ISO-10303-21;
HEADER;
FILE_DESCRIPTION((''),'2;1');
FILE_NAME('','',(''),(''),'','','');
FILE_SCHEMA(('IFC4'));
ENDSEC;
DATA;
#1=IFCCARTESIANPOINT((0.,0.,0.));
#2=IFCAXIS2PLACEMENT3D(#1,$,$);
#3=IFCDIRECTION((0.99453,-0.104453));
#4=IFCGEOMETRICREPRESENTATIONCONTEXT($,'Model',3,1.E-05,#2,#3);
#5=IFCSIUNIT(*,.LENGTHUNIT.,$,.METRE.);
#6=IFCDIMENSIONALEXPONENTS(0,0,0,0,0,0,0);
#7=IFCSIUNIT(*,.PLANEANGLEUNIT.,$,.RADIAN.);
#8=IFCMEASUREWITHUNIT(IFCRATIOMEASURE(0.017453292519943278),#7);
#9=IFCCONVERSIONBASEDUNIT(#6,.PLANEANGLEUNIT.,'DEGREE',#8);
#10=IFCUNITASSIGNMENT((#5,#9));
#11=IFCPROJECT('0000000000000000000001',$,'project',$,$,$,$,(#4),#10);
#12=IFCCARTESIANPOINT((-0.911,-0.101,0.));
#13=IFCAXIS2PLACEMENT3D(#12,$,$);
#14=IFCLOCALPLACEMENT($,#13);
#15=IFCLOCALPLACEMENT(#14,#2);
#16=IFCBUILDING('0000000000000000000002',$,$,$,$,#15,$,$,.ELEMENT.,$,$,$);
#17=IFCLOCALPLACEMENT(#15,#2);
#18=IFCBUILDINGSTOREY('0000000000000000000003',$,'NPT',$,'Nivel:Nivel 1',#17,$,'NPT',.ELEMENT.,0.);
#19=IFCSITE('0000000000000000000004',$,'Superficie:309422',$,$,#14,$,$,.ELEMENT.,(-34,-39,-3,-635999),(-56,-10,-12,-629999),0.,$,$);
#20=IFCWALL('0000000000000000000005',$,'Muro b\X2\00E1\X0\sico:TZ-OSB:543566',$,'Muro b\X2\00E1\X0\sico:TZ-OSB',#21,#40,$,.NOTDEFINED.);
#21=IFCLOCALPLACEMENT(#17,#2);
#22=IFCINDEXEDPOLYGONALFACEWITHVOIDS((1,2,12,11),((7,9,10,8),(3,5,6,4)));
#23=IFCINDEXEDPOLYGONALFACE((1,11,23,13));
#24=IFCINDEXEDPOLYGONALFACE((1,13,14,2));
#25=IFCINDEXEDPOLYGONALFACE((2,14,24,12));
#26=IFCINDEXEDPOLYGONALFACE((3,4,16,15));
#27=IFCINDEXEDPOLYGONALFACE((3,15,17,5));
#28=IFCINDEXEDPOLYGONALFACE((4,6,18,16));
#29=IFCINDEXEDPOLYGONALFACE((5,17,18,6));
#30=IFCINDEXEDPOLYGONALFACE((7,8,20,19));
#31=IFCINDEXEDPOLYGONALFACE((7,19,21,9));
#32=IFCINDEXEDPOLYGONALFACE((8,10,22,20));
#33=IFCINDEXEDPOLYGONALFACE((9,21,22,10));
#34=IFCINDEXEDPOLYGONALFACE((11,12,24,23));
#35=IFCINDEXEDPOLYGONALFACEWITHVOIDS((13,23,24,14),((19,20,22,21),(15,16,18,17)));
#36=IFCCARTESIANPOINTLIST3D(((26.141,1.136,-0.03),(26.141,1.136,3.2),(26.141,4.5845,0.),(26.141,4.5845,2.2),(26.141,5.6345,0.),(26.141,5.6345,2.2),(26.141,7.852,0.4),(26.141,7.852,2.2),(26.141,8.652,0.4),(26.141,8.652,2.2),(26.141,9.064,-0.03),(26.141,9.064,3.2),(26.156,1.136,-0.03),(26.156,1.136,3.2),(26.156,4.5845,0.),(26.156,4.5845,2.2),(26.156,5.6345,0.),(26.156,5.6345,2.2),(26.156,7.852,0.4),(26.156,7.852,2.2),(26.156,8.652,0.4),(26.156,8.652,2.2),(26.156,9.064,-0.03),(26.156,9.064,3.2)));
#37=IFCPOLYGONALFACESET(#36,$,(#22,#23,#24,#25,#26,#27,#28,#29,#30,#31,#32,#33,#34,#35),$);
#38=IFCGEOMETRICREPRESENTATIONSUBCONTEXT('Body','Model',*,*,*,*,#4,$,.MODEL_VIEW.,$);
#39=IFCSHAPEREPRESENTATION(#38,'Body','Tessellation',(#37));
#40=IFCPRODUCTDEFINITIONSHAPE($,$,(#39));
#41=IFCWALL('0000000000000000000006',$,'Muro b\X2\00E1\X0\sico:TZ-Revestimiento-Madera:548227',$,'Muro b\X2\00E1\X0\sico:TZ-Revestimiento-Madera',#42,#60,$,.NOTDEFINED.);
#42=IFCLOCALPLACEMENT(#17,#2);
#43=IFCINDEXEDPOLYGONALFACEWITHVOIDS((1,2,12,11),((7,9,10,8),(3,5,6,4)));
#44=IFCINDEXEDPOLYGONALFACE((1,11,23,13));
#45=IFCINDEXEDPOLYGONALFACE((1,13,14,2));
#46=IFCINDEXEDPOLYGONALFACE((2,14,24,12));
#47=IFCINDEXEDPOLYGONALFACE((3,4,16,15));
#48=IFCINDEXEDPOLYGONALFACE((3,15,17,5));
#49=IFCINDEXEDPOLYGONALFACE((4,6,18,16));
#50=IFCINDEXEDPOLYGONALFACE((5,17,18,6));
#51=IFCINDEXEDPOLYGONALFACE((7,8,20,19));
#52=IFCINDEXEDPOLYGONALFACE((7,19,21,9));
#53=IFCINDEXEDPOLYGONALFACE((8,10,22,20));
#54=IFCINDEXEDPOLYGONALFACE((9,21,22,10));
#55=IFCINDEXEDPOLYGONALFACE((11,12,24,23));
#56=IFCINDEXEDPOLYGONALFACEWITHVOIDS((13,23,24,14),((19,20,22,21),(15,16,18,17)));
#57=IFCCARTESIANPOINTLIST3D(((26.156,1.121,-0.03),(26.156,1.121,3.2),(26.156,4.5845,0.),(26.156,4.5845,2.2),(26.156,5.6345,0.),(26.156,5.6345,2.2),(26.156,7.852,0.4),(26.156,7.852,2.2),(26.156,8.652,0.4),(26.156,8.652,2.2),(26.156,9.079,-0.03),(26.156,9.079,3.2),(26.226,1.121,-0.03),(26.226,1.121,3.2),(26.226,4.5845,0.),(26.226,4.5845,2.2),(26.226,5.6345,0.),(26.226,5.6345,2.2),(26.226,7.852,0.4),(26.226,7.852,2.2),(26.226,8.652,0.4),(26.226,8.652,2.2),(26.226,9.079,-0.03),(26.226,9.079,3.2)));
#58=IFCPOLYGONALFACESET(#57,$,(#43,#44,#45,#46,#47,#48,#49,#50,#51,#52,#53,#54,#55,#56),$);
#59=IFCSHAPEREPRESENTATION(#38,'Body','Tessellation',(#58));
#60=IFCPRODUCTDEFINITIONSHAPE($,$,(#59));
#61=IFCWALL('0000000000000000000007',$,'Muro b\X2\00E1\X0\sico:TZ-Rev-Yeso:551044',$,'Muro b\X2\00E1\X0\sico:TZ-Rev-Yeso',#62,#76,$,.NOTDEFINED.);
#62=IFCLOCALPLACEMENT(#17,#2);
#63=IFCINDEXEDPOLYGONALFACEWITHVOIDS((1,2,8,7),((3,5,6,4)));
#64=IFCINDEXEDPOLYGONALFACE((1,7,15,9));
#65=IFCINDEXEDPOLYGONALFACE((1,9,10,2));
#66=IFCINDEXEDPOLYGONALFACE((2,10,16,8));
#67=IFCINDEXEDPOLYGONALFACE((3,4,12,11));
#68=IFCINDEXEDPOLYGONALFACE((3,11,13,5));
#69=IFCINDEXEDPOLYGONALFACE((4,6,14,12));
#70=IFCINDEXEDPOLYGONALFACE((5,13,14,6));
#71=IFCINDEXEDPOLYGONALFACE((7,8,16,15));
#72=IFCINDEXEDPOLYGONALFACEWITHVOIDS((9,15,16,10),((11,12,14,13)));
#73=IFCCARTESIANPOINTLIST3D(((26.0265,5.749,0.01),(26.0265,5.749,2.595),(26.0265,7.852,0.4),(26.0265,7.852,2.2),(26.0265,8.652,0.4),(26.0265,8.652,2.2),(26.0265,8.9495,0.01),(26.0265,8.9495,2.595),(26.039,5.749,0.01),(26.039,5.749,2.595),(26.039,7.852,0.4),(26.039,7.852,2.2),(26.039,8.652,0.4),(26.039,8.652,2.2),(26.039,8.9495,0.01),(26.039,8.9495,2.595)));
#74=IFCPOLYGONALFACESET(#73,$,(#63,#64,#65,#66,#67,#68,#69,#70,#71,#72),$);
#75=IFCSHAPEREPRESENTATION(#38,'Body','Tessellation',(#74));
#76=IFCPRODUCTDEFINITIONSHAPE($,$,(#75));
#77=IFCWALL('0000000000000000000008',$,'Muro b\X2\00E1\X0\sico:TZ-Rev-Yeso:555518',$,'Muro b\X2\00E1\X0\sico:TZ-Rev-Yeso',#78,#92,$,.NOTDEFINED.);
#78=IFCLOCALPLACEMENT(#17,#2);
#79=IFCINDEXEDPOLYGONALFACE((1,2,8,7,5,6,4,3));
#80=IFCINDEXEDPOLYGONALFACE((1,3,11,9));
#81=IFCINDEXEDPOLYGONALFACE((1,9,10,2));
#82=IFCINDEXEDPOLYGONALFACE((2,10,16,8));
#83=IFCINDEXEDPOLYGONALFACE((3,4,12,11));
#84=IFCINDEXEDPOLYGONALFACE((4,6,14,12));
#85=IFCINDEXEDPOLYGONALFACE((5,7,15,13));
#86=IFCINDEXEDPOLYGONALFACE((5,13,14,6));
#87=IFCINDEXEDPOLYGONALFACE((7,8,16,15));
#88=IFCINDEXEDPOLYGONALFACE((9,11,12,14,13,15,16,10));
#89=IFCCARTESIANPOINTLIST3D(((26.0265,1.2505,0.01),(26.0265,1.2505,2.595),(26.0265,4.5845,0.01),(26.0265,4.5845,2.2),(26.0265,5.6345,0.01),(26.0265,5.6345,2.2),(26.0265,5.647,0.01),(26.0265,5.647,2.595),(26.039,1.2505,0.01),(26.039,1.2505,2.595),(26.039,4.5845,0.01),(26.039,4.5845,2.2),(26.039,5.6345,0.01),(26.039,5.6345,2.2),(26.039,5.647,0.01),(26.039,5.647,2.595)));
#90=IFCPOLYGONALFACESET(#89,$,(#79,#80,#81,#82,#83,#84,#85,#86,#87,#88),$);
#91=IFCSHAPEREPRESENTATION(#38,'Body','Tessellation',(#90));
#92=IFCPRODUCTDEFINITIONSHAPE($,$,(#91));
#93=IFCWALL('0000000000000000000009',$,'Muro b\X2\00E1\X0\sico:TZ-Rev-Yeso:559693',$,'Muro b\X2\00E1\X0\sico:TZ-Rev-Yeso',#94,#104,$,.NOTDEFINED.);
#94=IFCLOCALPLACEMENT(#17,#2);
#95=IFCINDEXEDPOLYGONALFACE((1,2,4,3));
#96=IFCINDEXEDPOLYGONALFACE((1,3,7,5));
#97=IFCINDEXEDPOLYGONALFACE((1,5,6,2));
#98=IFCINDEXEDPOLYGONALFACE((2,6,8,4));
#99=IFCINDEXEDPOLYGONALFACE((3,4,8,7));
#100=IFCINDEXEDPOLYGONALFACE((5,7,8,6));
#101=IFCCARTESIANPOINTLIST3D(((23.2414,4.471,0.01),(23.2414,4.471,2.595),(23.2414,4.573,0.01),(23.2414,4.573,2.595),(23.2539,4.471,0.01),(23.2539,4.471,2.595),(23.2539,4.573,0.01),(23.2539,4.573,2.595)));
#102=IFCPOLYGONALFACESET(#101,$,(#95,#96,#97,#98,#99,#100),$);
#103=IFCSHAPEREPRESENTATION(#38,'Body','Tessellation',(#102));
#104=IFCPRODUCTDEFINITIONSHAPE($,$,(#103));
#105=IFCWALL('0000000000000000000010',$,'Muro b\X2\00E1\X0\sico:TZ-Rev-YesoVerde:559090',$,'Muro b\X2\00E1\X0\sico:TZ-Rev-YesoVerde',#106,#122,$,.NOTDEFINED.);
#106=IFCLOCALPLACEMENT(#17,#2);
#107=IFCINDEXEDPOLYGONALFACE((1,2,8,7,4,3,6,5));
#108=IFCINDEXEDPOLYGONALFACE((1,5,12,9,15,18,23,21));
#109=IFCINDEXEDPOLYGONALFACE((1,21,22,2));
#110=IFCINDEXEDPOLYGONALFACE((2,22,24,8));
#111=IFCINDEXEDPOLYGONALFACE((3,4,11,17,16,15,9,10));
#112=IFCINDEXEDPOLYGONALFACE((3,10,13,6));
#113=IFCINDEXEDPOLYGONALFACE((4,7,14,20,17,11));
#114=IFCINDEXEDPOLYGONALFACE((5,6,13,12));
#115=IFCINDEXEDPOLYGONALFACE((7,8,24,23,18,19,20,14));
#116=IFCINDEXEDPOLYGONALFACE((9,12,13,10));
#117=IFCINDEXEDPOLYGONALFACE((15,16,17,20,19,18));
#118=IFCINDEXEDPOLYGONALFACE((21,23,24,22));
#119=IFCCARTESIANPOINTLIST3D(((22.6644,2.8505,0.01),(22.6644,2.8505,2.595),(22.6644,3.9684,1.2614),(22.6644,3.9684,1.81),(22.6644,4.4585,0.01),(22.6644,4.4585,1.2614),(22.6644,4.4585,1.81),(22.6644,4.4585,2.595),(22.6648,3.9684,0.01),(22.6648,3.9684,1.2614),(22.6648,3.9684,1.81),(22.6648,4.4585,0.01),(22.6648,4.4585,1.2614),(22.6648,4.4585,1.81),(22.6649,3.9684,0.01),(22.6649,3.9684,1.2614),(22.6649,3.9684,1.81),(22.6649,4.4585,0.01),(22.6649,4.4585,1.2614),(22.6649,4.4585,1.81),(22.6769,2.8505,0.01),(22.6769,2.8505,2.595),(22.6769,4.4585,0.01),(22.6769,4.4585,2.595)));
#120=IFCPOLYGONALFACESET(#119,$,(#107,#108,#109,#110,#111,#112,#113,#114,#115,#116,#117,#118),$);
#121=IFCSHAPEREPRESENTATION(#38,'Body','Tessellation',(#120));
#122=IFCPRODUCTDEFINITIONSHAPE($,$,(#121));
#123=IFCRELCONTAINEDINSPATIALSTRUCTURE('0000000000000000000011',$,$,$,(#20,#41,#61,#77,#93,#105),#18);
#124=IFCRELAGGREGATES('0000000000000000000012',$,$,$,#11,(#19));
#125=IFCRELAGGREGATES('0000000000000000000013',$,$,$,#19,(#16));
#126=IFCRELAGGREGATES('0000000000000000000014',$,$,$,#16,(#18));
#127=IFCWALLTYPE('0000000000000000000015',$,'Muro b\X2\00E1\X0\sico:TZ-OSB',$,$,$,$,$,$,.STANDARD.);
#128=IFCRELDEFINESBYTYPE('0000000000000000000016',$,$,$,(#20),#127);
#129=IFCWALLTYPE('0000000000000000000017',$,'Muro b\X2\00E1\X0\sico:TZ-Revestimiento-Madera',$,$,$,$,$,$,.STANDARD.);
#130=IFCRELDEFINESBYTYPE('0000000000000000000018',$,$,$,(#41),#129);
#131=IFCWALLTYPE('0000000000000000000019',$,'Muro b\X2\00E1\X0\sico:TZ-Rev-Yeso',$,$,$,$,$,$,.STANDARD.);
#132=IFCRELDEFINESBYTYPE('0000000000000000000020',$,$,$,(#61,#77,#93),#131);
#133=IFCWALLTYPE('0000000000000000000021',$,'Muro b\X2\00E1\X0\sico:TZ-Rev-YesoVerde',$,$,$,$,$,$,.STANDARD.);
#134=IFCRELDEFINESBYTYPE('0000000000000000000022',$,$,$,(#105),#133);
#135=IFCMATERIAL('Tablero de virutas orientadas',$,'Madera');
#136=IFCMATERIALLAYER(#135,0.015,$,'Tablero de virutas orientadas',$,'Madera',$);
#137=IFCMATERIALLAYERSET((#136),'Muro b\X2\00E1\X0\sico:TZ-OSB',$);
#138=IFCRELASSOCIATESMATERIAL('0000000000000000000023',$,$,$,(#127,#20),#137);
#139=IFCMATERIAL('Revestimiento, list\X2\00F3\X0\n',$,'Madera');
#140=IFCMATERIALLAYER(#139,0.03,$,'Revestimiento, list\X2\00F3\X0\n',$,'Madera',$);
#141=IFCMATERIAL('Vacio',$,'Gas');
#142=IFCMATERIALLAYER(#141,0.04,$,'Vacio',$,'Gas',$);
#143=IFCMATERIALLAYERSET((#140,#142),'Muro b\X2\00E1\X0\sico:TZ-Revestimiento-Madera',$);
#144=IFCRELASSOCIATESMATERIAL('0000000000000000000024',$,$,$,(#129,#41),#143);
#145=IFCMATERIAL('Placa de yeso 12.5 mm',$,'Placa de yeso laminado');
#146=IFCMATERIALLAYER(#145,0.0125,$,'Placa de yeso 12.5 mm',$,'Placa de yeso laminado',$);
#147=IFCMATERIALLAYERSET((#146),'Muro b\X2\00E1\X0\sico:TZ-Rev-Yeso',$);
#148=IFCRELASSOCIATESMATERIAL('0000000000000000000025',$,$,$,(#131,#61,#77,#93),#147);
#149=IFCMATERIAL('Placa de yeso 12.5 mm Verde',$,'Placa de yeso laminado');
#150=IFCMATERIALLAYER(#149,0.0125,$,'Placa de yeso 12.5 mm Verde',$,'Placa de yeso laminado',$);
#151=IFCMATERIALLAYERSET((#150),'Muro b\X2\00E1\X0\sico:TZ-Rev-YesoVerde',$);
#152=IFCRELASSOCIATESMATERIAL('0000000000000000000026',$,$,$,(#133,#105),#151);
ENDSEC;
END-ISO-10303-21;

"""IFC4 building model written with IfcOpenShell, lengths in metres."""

from ifc_helpers import new_model, entity, si_unit, converted_unit, direction, frame, frame_2d, origin, place, context, subcontext, project, spatial, polyline, rectangle, extrude, clip, bounded_halfspace, material, layer, layer_set, layer_usage, type_object, element, save


model = new_model("IFC4")

# Units and contexts
model_context = context("Model", 3, precision=1e-05, world=origin(), true_north=direction((0.99453, -0.104453)))
body_context = subcontext(model_context, "Body", "Model", "MODEL_VIEW")
ifc_project = project(units=[si_unit("LENGTHUNIT", "METRE"), converted_unit("PLANEANGLEUNIT", "DEGREE", entity("IfcRatioMeasure", 0.017453292519943278), si_unit("PLANEANGLEUNIT", "RADIAN"), dimensions=[0, 0, 0, 0, 0, 0, 0])], contexts=[model_context])

# Site, building, storey
site_placement = place(None, frame((-0.911, -0.101, 0.0)))
site = spatial("IfcSite", under=ifc_project, at=site_placement, Name="Superficie:309422", CompositionType="ELEMENT", RefLatitude=(-34, -39, -3, -635999), RefLongitude=(-56, -10, -12, -629999), RefElevation=0.0)
building_placement = place(site_placement, origin())
building = spatial("IfcBuilding", under=site, at=building_placement, CompositionType="ELEMENT")
storey_placement = place(building_placement, origin())
storey = spatial("IfcBuildingStorey", under=building, at=storey_placement, Name="NPT", ObjectType="Nivel:Nivel 1", LongName="NPT", CompositionType="ELEMENT", Elevation=0.0)

# Walls, openings
ifc_material_1 = material(Name="Tablero de virutas orientadas", Category="Madera")
ifc_layer_1 = layer(ifc_material_1, 0.015, Name="Tablero de virutas orientadas", Category="Madera")
ifc_layer_set_1 = layer_set([ifc_layer_1], Name="Muro básico:TZ-OSB")
ifc_layer_usage_1 = layer_usage(ifc_layer_set_1, "AXIS2", "NEGATIVE", 0.0075)
wall_type_1 = type_object("IfcWallType", Name="Muro básico:TZ-OSB", PredefinedType="STANDARD", material=ifc_layer_set_1)
wall_1_placement = place(storey_placement, frame((26.1485, 9.064, -0.03), z_axis=(0.0, 0.0, 1.0), x_axis=(0.0, -1.0, 0.0)))
wall_1 = element("IfcWall", 1, at=wall_1_placement, inside=storey, type_object=wall_type_1, material=ifc_layer_usage_1, Name="Muro básico:TZ-OSB:543566", ObjectType="Muro básico:TZ-OSB", PredefinedType="NOTDEFINED", context=body_context, shape_type="SweptSolid", body=[
    extrude(rectangle(XDim=7.928, YDim=0.015, at=frame_2d((3.964, 0.0), x_axis=(-1.0, 0.0))), origin(), (0.0, 0.0, 1.0), 3.23),
])
opening_1_placement = place(wall_1_placement, frame((4.4795, -1.6335, 0.03)))
element("IfcOpeningElement", 2, at=opening_1_placement, cuts=wall_1, PredefinedType="OPENING", context=body_context, shape_type="SweptSolid", body=[
    extrude(rectangle(XDim=2.2, YDim=1.05, at=frame_2d((0.0, 0.0), x_axis=(1.0, 0.0))), frame((-0.525, 0.0, 1.1), z_axis=(0.0, 1.0, 0.0), x_axis=(0.0, 0.0, 1.0)), (0.0, 0.0, 1.0), 3.048),
])
opening_2_placement = place(wall_1_placement, frame((1.212, -1.6335, 0.43)))
element("IfcOpeningElement", 3, at=opening_2_placement, cuts=wall_1, PredefinedType="OPENING", context=body_context, shape_type="SweptSolid", body=[
    extrude(rectangle(XDim=1.8, YDim=0.8, at=frame_2d((0.0, 0.0), x_axis=(0.0, 1.0))), frame((-0.4, 0.0, 0.9), z_axis=(0.0, 1.0, 0.0), x_axis=(-1.0, 0.0, 0.0)), (0.0, 0.0, 1.0), 3.048),
])
ifc_material_2 = material(Name="Revestimiento, listón", Category="Madera")
ifc_layer_2 = layer(ifc_material_2, 0.03, Name="Revestimiento, listón", Category="Madera")
ifc_material_3 = material(Name="Vacio", Category="Gas")
ifc_layer_3 = layer(ifc_material_3, 0.04, Name="Vacio", Category="Gas")
ifc_layer_set_2 = layer_set([ifc_layer_2, ifc_layer_3], Name="Muro básico:TZ-Revestimiento-Madera")
ifc_layer_usage_2 = layer_usage(ifc_layer_set_2, "AXIS2", "NEGATIVE", 0.035)
wall_type_2 = type_object("IfcWallType", Name="Muro básico:TZ-Revestimiento-Madera", PredefinedType="STANDARD", material=ifc_layer_set_2)
wall_2_placement = place(storey_placement, frame((26.191, 9.079, -0.03), z_axis=(0.0, 0.0, 1.0), x_axis=(0.0, -1.0, 0.0)))
wall_2 = element("IfcWall", 4, at=wall_2_placement, inside=storey, type_object=wall_type_2, material=ifc_layer_usage_2, Name="Muro básico:TZ-Revestimiento-Madera:548227", ObjectType="Muro básico:TZ-Revestimiento-Madera", PredefinedType="NOTDEFINED", context=body_context, shape_type="SweptSolid", body=[
    extrude(rectangle(XDim=7.958, YDim=0.07, at=frame_2d((3.979, 0.0), x_axis=(1.0, 0.0))), origin(), (0.0, 0.0, 1.0), 3.23),
])
opening_3_placement = place(wall_2_placement, frame((4.4945, -1.676, 0.03)))
element("IfcOpeningElement", 5, at=opening_3_placement, cuts=wall_2, PredefinedType="OPENING", context=body_context, shape_type="SweptSolid", body=[
    extrude(rectangle(XDim=2.2, YDim=1.05, at=frame_2d((0.0, 0.0), x_axis=(1.0, 0.0))), frame((-0.525, 0.0, 1.1), z_axis=(0.0, 1.0, 0.0), x_axis=(0.0, 0.0, 1.0)), (0.0, 0.0, 1.0), 3.048),
])
opening_4_placement = place(wall_2_placement, frame((1.227, -1.676, 0.43)))
element("IfcOpeningElement", 6, at=opening_4_placement, cuts=wall_2, PredefinedType="OPENING", context=body_context, shape_type="SweptSolid", body=[
    extrude(rectangle(XDim=1.8, YDim=0.8, at=frame_2d((0.0, 0.0), x_axis=(0.0, 1.0))), frame((-0.4, 0.0, 0.9), z_axis=(0.0, 1.0, 0.0), x_axis=(-1.0, 0.0, 0.0)), (0.0, 0.0, 1.0), 3.048),
])

# Wall, opening
ifc_material_4 = material(Name="Placa de yeso 12.5 mm", Category="Placa de yeso laminado")
ifc_layer_4 = layer(ifc_material_4, 0.0125, Name="Placa de yeso 12.5 mm", Category="Placa de yeso laminado")
ifc_layer_set_3 = layer_set([ifc_layer_4], Name="Muro básico:TZ-Rev-Yeso")
ifc_layer_usage_3 = layer_usage(ifc_layer_set_3, "AXIS2", "NEGATIVE", 0.0063)
wall_type_3 = type_object("IfcWallType", Name="Muro básico:TZ-Rev-Yeso", PredefinedType="STANDARD", material=ifc_layer_set_3)
wall_3_placement = place(storey_placement, frame((26.0327, 8.9495, 0.01), z_axis=(0.0, 0.0, 1.0), x_axis=(0.0, -1.0, 0.0)))
wall_3 = element("IfcWall", 7, at=wall_3_placement, inside=storey, type_object=wall_type_3, material=ifc_layer_usage_3, Name="Muro básico:TZ-Rev-Yeso:551044", ObjectType="Muro básico:TZ-Rev-Yeso", PredefinedType="NOTDEFINED", context=body_context, shape_type="SweptSolid", body=[
    extrude(rectangle(XDim=3.2005, YDim=0.0125, at=frame_2d((1.6003, 0.0), x_axis=(-1.0, 0.0))), origin(), (0.0, 0.0, 1.0), 2.585),
])
opening_5_placement = place(wall_3_placement, frame((1.0975, -1.5178, 0.39)))
element("IfcOpeningElement", 8, at=opening_5_placement, cuts=wall_3, PredefinedType="OPENING", context=body_context, shape_type="SweptSolid", body=[
    extrude(rectangle(XDim=1.8, YDim=0.8, at=frame_2d((0.0, 0.0), x_axis=(0.0, 1.0))), frame((-0.4, 0.0, 0.9), z_axis=(0.0, 1.0, 0.0), x_axis=(-1.0, 0.0, 0.0)), (0.0, 0.0, 1.0), 3.048),
])

# Wall, opening
ifc_layer_usage_4 = layer_usage(ifc_layer_set_3, "AXIS2", "NEGATIVE", 0.0063)
wall_4_placement = place(storey_placement, frame((26.0327, 5.647, 0.01), z_axis=(0.0, 0.0, 1.0), x_axis=(0.0, -1.0, 0.0)))
wall_4 = element("IfcWall", 9, at=wall_4_placement, inside=storey, type_object=wall_type_3, material=ifc_layer_usage_4, Name="Muro básico:TZ-Rev-Yeso:555518", ObjectType="Muro básico:TZ-Rev-Yeso", PredefinedType="NOTDEFINED", context=body_context, shape_type="SweptSolid", body=[
    extrude(rectangle(XDim=4.3965, YDim=0.0125, at=frame_2d((2.1982, 0.0), x_axis=(1.0, 0.0))), origin(), (0.0, 0.0, 1.0), 2.585),
])
opening_6_placement = place(wall_4_placement, frame((1.0625, -1.5178, -0.01)))
element("IfcOpeningElement", 10, at=opening_6_placement, cuts=wall_4, PredefinedType="OPENING", context=body_context, shape_type="SweptSolid", body=[
    extrude(rectangle(XDim=2.2, YDim=1.05, at=frame_2d((0.0, 0.0), x_axis=(1.0, 0.0))), frame((-0.525, 0.0, 1.1), z_axis=(0.0, 1.0, 0.0), x_axis=(0.0, 0.0, 1.0)), (0.0, 0.0, 1.0), 3.048),
])

# Wall
ifc_layer_usage_5 = layer_usage(ifc_layer_set_3, "AXIS2", "NEGATIVE", 0.0063)
wall_5_placement = place(storey_placement, frame((23.2477, 4.471, 0.01), z_axis=(0.0, 0.0, 1.0), x_axis=(0.0, 1.0, 0.0)))
element("IfcWall", 11, at=wall_5_placement, inside=storey, type_object=wall_type_3, material=ifc_layer_usage_5, Name="Muro básico:TZ-Rev-Yeso:559693", ObjectType="Muro básico:TZ-Rev-Yeso", PredefinedType="NOTDEFINED", context=body_context, shape_type="SweptSolid", body=[
    extrude(rectangle(XDim=0.102, YDim=0.0125, at=frame_2d((0.051, 0.0), x_axis=(-1.0, 0.0))), origin(), (0.0, 0.0, 1.0), 2.585),
])

# Wall
ifc_material_5 = material(Name="Placa de yeso 12.5 mm Verde", Category="Placa de yeso laminado")
ifc_layer_5 = layer(ifc_material_5, 0.0125, Name="Placa de yeso 12.5 mm Verde", Category="Placa de yeso laminado")
ifc_layer_set_4 = layer_set([ifc_layer_5], Name="Muro básico:TZ-Rev-YesoVerde")
ifc_layer_usage_6 = layer_usage(ifc_layer_set_4, "AXIS2", "NEGATIVE", 0.0063)
wall_type_4 = type_object("IfcWallType", Name="Muro básico:TZ-Rev-YesoVerde", PredefinedType="STANDARD", material=ifc_layer_set_4)
wall_6_placement = place(storey_placement, frame((22.6707, 4.4585, 0.01), z_axis=(0.0, 0.0, 1.0), x_axis=(0.0, -1.0, 0.0)))
element("IfcWall", 12, at=wall_6_placement, inside=storey, type_object=wall_type_4, material=ifc_layer_usage_6, Name="Muro básico:TZ-Rev-YesoVerde:559090", ObjectType="Muro básico:TZ-Rev-YesoVerde", PredefinedType="NOTDEFINED", context=body_context, shape_type="Clipping", body=[
    clip(clip(extrude(rectangle(XDim=1.608, YDim=0.0125, at=frame_2d((0.804, 0.0), x_axis=(-1.0, 0.0))), origin(), (0.0, 0.0, 1.0), 2.585), bounded_halfspace(frame((0.0, -0.0058, 1.8), z_axis=(0.0, 1.0, 0.0), x_axis=(-1.0, 0.0, 0.0)), True, frame((0.0, -0.0058, 1.8), z_axis=(0.0, 1.0, 0.0), x_axis=(-1.0, 0.0, 0.0)), polyline([(0.0, 0.0), (-0.4865, 0.0), (-0.4901, 0.0), (-0.4901, -0.5486), (-0.4865, -0.5486), (0.0, -0.5486), (0.0, 0.0)]))), bounded_halfspace(frame((0.0, -0.0058, 1.8), z_axis=(0.0, 0.0, 1.0), x_axis=(0.0, 1.0, 0.0)), True, frame((0.0, -0.0058, 1.8), z_axis=(0.0, 0.0, 1.0), x_axis=(0.0, 1.0, 0.0)), polyline([(0.0, 0.0), (-0.0002, 0.0), (-0.0002, -0.4901), (0.0, -0.4901), (0.0, -0.4865), (0.0, 0.0)]))),
])

save(model, "model.ifc")
